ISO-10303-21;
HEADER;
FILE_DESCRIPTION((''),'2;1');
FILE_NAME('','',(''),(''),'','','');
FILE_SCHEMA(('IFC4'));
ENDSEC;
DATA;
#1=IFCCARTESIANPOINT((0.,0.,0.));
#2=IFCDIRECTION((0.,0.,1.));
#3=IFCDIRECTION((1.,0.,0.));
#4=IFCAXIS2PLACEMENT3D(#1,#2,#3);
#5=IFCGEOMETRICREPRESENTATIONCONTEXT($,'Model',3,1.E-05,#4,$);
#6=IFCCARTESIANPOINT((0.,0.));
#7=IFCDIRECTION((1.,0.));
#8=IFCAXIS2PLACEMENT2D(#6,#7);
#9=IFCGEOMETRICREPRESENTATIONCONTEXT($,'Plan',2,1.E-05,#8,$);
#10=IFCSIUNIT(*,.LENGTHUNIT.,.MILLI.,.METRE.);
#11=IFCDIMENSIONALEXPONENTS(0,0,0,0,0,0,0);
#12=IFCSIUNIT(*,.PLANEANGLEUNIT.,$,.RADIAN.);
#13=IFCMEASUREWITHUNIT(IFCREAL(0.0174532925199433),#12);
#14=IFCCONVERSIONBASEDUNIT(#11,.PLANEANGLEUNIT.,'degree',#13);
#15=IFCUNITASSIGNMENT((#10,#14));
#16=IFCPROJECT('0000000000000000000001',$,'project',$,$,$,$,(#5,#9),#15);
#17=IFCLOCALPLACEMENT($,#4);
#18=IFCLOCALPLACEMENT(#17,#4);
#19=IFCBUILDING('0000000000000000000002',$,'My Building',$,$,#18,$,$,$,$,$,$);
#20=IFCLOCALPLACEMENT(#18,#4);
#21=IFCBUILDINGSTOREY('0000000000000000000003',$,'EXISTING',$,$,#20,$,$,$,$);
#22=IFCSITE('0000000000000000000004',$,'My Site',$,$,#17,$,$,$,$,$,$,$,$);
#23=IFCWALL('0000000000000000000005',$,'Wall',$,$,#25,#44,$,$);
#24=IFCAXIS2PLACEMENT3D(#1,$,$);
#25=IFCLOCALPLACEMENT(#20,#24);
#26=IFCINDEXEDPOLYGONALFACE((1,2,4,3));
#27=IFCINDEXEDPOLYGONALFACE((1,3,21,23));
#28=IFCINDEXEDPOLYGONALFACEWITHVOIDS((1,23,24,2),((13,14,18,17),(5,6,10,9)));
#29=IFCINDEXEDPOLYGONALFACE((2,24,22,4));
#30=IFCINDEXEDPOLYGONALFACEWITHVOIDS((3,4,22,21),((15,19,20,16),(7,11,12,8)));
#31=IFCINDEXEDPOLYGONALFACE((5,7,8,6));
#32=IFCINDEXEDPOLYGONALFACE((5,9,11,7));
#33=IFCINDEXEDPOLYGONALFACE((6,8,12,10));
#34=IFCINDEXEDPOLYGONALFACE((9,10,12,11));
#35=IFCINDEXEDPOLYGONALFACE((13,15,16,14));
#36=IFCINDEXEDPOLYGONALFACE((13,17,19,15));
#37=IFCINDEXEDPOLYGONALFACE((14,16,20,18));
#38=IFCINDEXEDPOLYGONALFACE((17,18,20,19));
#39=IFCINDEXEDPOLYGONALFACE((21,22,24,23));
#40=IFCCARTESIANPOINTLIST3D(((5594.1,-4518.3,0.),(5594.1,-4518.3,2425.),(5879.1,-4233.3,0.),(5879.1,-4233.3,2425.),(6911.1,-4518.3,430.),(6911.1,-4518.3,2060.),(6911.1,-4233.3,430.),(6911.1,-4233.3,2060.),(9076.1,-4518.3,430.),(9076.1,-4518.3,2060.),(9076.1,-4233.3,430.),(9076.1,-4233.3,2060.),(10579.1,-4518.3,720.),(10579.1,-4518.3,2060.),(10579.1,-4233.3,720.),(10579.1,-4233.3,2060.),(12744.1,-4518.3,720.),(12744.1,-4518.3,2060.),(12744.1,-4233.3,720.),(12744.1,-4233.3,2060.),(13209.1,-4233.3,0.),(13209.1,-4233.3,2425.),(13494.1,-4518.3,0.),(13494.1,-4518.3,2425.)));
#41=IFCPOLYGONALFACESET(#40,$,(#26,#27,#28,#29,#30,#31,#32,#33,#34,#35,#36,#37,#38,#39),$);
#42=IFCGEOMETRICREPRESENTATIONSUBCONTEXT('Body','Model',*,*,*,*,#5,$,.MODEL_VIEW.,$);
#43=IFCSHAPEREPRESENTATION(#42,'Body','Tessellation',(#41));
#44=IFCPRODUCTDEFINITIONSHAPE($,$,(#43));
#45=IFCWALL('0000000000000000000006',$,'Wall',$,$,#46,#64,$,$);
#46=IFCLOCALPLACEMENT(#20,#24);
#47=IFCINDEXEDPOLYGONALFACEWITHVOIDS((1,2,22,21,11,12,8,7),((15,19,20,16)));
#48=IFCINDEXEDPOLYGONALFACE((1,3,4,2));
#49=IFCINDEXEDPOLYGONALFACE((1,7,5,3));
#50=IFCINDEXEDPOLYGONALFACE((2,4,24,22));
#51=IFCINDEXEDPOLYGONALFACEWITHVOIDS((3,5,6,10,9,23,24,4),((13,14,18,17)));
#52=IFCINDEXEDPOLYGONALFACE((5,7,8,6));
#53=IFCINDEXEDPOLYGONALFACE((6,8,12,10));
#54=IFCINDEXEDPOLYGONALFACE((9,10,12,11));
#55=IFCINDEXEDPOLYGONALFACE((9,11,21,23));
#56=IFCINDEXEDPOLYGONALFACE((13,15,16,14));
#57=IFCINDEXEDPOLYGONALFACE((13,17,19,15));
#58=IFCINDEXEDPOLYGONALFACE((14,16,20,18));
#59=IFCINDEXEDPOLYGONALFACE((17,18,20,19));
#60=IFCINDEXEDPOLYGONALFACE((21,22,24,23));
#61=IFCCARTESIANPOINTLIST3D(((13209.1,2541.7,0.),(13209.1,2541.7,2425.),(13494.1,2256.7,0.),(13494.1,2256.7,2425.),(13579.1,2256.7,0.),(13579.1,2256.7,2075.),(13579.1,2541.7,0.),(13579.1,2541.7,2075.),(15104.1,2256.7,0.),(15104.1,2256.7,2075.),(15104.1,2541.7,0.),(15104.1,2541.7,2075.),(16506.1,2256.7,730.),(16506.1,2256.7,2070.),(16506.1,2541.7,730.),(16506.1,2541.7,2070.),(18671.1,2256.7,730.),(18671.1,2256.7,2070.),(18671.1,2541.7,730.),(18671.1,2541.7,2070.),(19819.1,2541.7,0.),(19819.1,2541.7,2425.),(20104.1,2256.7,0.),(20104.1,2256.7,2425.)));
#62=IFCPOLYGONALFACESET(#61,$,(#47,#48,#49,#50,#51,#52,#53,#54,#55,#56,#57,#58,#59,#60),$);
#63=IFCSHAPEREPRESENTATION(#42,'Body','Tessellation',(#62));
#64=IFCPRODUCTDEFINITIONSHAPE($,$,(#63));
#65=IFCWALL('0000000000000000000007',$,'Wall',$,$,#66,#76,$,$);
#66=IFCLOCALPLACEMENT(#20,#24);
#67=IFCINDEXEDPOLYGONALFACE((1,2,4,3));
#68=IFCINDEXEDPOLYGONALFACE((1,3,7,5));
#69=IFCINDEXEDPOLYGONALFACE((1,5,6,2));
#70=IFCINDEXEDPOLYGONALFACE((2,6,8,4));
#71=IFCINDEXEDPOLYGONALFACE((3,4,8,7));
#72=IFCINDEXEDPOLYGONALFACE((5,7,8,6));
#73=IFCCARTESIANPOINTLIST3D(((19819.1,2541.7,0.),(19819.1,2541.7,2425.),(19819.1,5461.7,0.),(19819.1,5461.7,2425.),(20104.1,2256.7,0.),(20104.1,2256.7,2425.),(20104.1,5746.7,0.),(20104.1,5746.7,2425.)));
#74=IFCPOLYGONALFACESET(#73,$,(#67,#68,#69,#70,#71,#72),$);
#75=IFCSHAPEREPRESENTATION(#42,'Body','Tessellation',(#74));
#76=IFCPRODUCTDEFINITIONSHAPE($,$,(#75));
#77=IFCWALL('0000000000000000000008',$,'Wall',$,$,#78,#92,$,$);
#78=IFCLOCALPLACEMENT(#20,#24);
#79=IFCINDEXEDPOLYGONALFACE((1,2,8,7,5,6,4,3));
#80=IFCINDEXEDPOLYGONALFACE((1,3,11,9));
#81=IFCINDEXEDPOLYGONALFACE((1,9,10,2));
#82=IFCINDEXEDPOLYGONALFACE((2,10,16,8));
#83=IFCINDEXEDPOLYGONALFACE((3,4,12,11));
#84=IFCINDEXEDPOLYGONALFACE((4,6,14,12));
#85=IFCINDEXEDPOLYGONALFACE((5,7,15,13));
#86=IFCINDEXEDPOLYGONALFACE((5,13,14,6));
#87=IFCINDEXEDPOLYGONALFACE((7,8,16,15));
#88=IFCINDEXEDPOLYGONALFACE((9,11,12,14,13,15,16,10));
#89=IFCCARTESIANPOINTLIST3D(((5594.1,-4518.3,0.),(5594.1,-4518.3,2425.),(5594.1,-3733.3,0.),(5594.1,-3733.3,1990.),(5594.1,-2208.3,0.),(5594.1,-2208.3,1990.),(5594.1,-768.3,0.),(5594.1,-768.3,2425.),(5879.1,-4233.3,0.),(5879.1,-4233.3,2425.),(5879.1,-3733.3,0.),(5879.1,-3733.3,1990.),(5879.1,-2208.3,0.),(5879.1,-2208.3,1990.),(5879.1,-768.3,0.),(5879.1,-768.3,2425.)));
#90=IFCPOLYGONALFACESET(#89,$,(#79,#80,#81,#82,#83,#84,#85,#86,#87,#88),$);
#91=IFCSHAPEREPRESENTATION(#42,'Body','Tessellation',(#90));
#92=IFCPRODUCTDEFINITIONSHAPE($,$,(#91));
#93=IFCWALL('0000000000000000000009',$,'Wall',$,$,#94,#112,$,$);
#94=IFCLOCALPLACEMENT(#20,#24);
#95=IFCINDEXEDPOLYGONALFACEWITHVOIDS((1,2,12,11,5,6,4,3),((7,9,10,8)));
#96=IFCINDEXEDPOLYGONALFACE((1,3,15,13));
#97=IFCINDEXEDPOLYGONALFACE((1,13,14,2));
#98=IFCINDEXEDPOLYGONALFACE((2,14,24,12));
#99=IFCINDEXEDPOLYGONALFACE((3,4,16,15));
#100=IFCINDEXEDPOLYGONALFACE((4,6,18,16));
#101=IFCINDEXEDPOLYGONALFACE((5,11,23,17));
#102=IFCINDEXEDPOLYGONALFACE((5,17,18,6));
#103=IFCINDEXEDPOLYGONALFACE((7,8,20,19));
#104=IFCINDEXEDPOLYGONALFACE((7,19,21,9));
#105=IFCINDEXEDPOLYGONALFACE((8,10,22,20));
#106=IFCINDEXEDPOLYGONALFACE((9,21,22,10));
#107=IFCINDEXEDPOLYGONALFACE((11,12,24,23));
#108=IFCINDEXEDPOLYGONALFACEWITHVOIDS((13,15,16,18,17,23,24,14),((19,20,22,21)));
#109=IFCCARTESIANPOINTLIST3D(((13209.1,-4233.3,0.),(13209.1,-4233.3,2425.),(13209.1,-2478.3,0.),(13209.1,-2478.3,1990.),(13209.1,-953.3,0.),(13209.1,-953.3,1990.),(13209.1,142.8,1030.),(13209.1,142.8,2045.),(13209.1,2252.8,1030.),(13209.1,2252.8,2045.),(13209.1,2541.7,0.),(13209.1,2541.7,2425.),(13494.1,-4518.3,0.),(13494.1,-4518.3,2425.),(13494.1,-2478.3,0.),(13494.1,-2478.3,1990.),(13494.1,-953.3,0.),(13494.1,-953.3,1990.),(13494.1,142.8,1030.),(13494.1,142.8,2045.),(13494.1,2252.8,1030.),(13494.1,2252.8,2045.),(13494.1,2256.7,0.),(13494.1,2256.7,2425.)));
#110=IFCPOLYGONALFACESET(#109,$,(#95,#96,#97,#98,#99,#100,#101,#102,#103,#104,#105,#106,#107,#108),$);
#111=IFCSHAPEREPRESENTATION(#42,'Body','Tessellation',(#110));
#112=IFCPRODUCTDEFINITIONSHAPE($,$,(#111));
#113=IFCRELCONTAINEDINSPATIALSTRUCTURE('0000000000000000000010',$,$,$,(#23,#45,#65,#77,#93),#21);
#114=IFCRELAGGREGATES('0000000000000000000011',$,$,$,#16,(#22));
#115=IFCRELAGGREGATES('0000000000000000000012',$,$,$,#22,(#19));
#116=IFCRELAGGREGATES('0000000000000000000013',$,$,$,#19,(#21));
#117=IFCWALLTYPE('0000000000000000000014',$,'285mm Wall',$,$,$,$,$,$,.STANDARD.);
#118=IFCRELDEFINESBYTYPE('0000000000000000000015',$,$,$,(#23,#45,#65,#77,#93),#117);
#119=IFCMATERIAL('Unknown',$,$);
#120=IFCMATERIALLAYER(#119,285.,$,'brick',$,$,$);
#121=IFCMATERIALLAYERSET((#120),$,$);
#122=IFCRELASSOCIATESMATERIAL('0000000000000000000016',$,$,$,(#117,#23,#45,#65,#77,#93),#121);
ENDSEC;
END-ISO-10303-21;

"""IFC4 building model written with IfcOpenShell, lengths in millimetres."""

from ifc_helpers import new_model, entity, si_unit, converted_unit, frame, origin_with_axes, origin_2d_with_axis, place, context, subcontext, project, spatial, line, indexed_curve, outline, extrude, clip, halfspace, source, transform, mapped, material, layer, layer_set, layer_usage, type_object, element, save


model = new_model("IFC4")

# Units and contexts
model_context = context("Model", 3, precision=1e-05, world=origin_with_axes())
plan_context = context("Plan", 2, precision=1e-05, world=origin_2d_with_axis())
body_context = subcontext(model_context, "Body", "Model", "MODEL_VIEW")
ifc_project = project(units=[si_unit("LENGTHUNIT", "METRE", prefix="MILLI"), converted_unit("PLANEANGLEUNIT", "degree", entity("IfcReal", 0.0174532925199433), si_unit("PLANEANGLEUNIT", "RADIAN"), dimensions=[0, 0, 0, 0, 0, 0, 0])], contexts=[model_context, plan_context])

# Site, building, storey
site_placement = place(None, origin_with_axes())
site = spatial("IfcSite", under=ifc_project, at=site_placement, Name="My Site")
building_placement = place(site_placement, origin_with_axes())
building = spatial("IfcBuilding", under=site, at=building_placement, Name="My Building")
storey_placement = place(building_placement, origin_with_axes())
storey = spatial("IfcBuildingStorey", under=building, at=storey_placement, Name="EXISTING")

# Shared definitions
ifc_material = material(Name="Unknown")

# Walls, openings
ifc_layer_1 = layer(ifc_material, 285.0, Name="brick")
ifc_layer_set_1 = layer_set([ifc_layer_1])
ifc_layer_usage_1 = layer_usage(ifc_layer_set_1, "AXIS2", "POSITIVE", 0.0)
wall_type_1 = type_object("IfcWallType", Name="285mm Wall", PredefinedType="STANDARD", material=ifc_layer_set_1)
wall_1_placement = place(storey_placement, frame((5594.1, -4518.3, 0.0), z_axis=(0.0, 0.0, 1.0), x_axis=(1.0, 0.0, 0.0)))
wall_1 = element("IfcWall", 1, at=wall_1_placement, inside=storey, type_object=wall_type_1, material=ifc_layer_usage_1, Name="Wall", context=body_context, shape_type="Clipping", body=[
    clip(clip(extrude(outline(indexed_curve([(0.0, 0.0), (0.0, 285.0), (7900.0, 285.0), (7900.0, 0.0), (0.0, 0.0)], self_intersect=False)), origin_with_axes(), (0.0, 0.0, 1.0), 2425.0), halfspace(frame((7900.0, 0.0, 0.0), z_axis=(0.707107, 0.707106, 0.0), x_axis=(0.707106, -0.707107, 0.0)), False)), halfspace(frame((0.0, 0.0, 0.0), z_axis=(-0.707106, 0.707107, 0.0), x_axis=(0.707107, 0.707106, 0.0)), False)),
])
shared_shape_1 = source(origin_with_axes(), body_context, "Body", "SweptSolid", [
    extrude(outline(indexed_curve([(0.0, 0.0), (2165.0, 0.0), (2165.0, 1630.0), (0.0, 1630.0)], segments=[line(1, 2, 3, 4, 1)])), frame((0.0, -600.0, 0.0), z_axis=(0.0, -1.0, 0.0), x_axis=(1.0, 0.0, 0.0)), (0.0, 0.0, -1.0), 1200.0),
])
opening_1_placement = place(wall_1_placement, frame((3482.0, 136.1, 430.0), z_axis=(0.0, 0.0, 1.0), x_axis=(-1.0, 0.0, 0.0)))
element("IfcOpeningElement", 2, at=opening_1_placement, cuts=wall_1, PredefinedType="OPENING", context=body_context, shape_type="MappedRepresentation", body=[
    mapped(shared_shape_1, transform((0.0, 0.0, 0.0), x_axis=(1.0, 0.0, 0.0), y_axis=(0.0, 1.0, 0.0), z_axis=(0.0, 0.0, 1.0), scale=1.0)),
])
shared_shape_2 = source(origin_with_axes(), body_context, "Body", "SweptSolid", [
    extrude(outline(indexed_curve([(0.0, 0.0), (2165.0, 0.0), (2165.0, 1340.0), (0.0, 1340.0)], segments=[line(1, 2, 3, 4, 1)])), frame((0.0, -600.0, 0.0), z_axis=(0.0, -1.0, 0.0), x_axis=(1.0, 0.0, 0.0)), (0.0, 0.0, -1.0), 1200.0),
])
opening_2_placement = place(wall_1_placement, frame((7150.0, 136.1, 720.0), z_axis=(0.0, 0.0, 1.0), x_axis=(-1.0, 0.0, 0.0)))
element("IfcOpeningElement", 3, at=opening_2_placement, cuts=wall_1, PredefinedType="OPENING", context=body_context, shape_type="MappedRepresentation", body=[
    mapped(shared_shape_2, transform((0.0, 0.0, 0.0), x_axis=(1.0, 0.0, 0.0), y_axis=(0.0, 1.0, 0.0), z_axis=(0.0, 0.0, 1.0), scale=1.0)),
])
ifc_layer_usage_2 = layer_usage(ifc_layer_set_1, "AXIS2", "POSITIVE", 0.0)
wall_2_placement = place(storey_placement, frame((13209.1, 2256.7, 0.0), z_axis=(0.0, 0.0, 1.0), x_axis=(1.0, 0.0, 0.0)))
wall_2 = element("IfcWall", 4, at=wall_2_placement, inside=storey, type_object=wall_type_1, material=ifc_layer_usage_2, Name="Wall", context=body_context, shape_type="Clipping", body=[
    clip(clip(extrude(outline(indexed_curve([(0.0, 0.0), (0.0, 285.0), (6895.0, 285.0), (6895.0, 0.0), (0.0, 0.0)], self_intersect=False)), origin_with_axes(), (0.0, 0.0, 1.0), 2425.0), halfspace(frame((285.0, 0.0, 0.0), z_axis=(-0.707107, -0.707107, 0.0), x_axis=(-0.707107, 0.707107, 0.0)), False)), halfspace(frame((6895.0, 0.0, 0.0), z_axis=(0.707107, 0.707107, 0.0), x_axis=(0.707107, -0.707107, 0.0)), False)),
])
opening_3_placement = place(wall_2_placement, frame((5462.0, 136.1, 730.0), z_axis=(0.0, 0.0, 1.0), x_axis=(-1.0, 0.0, 0.0)))
element("IfcOpeningElement", 5, at=opening_3_placement, cuts=wall_2, PredefinedType="OPENING", context=body_context, shape_type="MappedRepresentation", body=[
    mapped(shared_shape_2, transform((0.0, 0.0, 0.0), x_axis=(1.0, 0.0, 0.0), y_axis=(0.0, 1.0, 0.0), z_axis=(0.0, 0.0, 1.0), scale=1.0)),
])
shared_shape_3 = source(origin_with_axes(), body_context, "Body", "SweptSolid", [
    extrude(outline(indexed_curve([(0.0, 0.0), (1525.0, 0.0), (1525.0, 2075.0), (0.0, 2075.0)], segments=[line(1, 2, 3, 4, 1)])), frame((0.0, -600.0, 0.0), z_axis=(0.0, -1.0, 0.0), x_axis=(1.0, 0.0, 0.0)), (0.0, 0.0, -1.0), 1200.0),
])
opening_4_placement = place(wall_2_placement, frame((1895.0, -33.8, 0.0), z_axis=(0.0, 0.0, 1.0), x_axis=(-1.0, 0.0, 0.0)))
element("IfcOpeningElement", 6, at=opening_4_placement, cuts=wall_2, PredefinedType="OPENING", context=body_context, shape_type="MappedRepresentation", body=[
    mapped(shared_shape_3, transform((0.0, 0.0, 0.0), x_axis=(1.0, 0.0, 0.0), y_axis=(0.0, 1.0, 0.0), z_axis=(0.0, 0.0, 1.0), scale=1.0)),
])

# Wall
ifc_layer_usage_3 = layer_usage(ifc_layer_set_1, "AXIS2", "POSITIVE", 0.0)
wall_3_placement = place(storey_placement, frame((20104.1, 2256.7, 0.0), z_axis=(0.0, 0.0, 1.0), x_axis=(0.0, 1.0, 0.0)))
element("IfcWall", 7, at=wall_3_placement, inside=storey, type_object=wall_type_1, material=ifc_layer_usage_3, Name="Wall", context=body_context, shape_type="Clipping", body=[
    clip(clip(extrude(outline(indexed_curve([(0.0, 0.0), (0.0, 285.0), (3490.0, 285.0), (3490.0, 0.0), (0.0, 0.0)], self_intersect=False)), origin_with_axes(), (0.0, 0.0, 1.0), 2425.0), halfspace(frame((0.0, 0.0, 0.0), z_axis=(-0.707107, 0.707107, 0.0), x_axis=(0.707107, 0.707107, 0.0)), False)), halfspace(frame((3490.0, 0.0, 0.0), z_axis=(0.707107, 0.707107, 0.0), x_axis=(0.707107, -0.707107, 0.0)), False)),
])

# Wall, opening
ifc_layer_usage_4 = layer_usage(ifc_layer_set_1, "AXIS2", "POSITIVE", 0.0)
wall_4_placement = place(storey_placement, frame((5879.1, -4518.3, 0.0), z_axis=(0.0, 0.0, 1.0), x_axis=(0.0, 1.0, 0.0)))
wall_4 = element("IfcWall", 8, at=wall_4_placement, inside=storey, type_object=wall_type_1, material=ifc_layer_usage_4, Name="Wall", context=body_context, shape_type="Clipping", body=[
    clip(extrude(outline(indexed_curve([(0.0, 0.0), (0.0, 285.0), (3750.0, 285.0), (3750.0, 0.0), (0.0, 0.0)], self_intersect=False)), origin_with_axes(), (0.0, 0.0, 1.0), 2425.0), halfspace(frame((285.0, 0.0, 0.0), z_axis=(-0.707107, -0.707107, 0.0), x_axis=(-0.707107, 0.707107, 0.0)), False)),
])
shared_shape_4 = source(origin_with_axes(), body_context, "Body", "SweptSolid", [
    extrude(outline(indexed_curve([(0.0, 0.0), (1525.0, 0.0), (1525.0, 1990.0), (0.0, 1990.0)], segments=[line(1, 2, 3, 4, 1)])), frame((0.0, -600.0, 0.0), z_axis=(0.0, -1.0, 0.0), x_axis=(1.0, 0.0, 0.0)), (0.0, 0.0, -1.0), 1200.0),
])
opening_5_placement = place(wall_4_placement, frame((785.0, 0.0, 0.0), z_axis=(0.0, 0.0, 1.0), x_axis=(1.0, 0.0, 0.0)))
element("IfcOpeningElement", 9, at=opening_5_placement, cuts=wall_4, PredefinedType="OPENING", context=body_context, shape_type="MappedRepresentation", body=[
    mapped(shared_shape_4, transform((0.0, 0.0, 0.0), x_axis=(1.0, 0.0, 0.0), y_axis=(0.0, 1.0, 0.0), z_axis=(0.0, 0.0, 1.0), scale=1.0)),
])

# Wall, openings
ifc_layer_usage_5 = layer_usage(ifc_layer_set_1, "AXIS2", "POSITIVE", 0.0)
wall_5_placement = place(storey_placement, frame((13494.1, -4518.3, 0.0), z_axis=(0.0, 0.0, 1.0), x_axis=(0.0, 1.0, 0.0)))
wall_5 = element("IfcWall", 10, at=wall_5_placement, inside=storey, type_object=wall_type_1, material=ifc_layer_usage_5, Name="Wall", context=body_context, shape_type="Clipping", body=[
    clip(clip(extrude(outline(indexed_curve([(0.0, 0.0), (0.0, 285.0), (7060.0, 285.0), (7060.0, 0.0), (0.0, 0.0)], self_intersect=False)), origin_with_axes(), (0.0, 0.0, 1.0), 2425.0), halfspace(frame((0.0, 0.0, 0.0), z_axis=(-0.707107, 0.707107, 0.0), x_axis=(0.707107, 0.707107, 0.0)), False)), halfspace(frame((6775.0, 0.0, 0.0), z_axis=(0.707107, -0.707107, 0.0), x_axis=(-0.707107, -0.707107, 0.0)), False)),
])
shared_shape_5 = source(origin_with_axes(), body_context, "Body", "SweptSolid", [
    extrude(outline(indexed_curve([(0.0, 0.0), (2110.0, 0.0), (2110.0, 1015.0), (0.0, 1015.0)], segments=[line(1, 2, 3, 4, 1)])), frame((0.0, -600.0, 0.0), z_axis=(0.0, -1.0, 0.0), x_axis=(1.0, 0.0, 0.0)), (0.0, 0.0, -1.0), 1200.0),
])
opening_6_placement = place(wall_5_placement, frame((6771.2, 136.1, 1030.0), z_axis=(0.0, 0.0, 1.0), x_axis=(-1.0, 0.0, 0.0)))
element("IfcOpeningElement", 11, at=opening_6_placement, cuts=wall_5, PredefinedType="OPENING", context=body_context, shape_type="MappedRepresentation", body=[
    mapped(shared_shape_5, transform((0.0, 0.0, 0.0), x_axis=(1.0, 0.0, 0.0), y_axis=(0.0, 1.0, 0.0), z_axis=(0.0, 0.0, 1.0), scale=1.0)),
])
shared_shape_6 = source(origin_with_axes(), body_context, "Body", "SweptSolid", [
    extrude(outline(indexed_curve([(0.0, 0.0), (1525.0, 0.0), (1525.0, 1990.0), (0.0, 1990.0)], segments=[line(1, 2, 3, 4, 1)])), frame((0.0, -600.0, 0.0), z_axis=(0.0, -1.0, 0.0), x_axis=(1.0, 0.0, 0.0)), (0.0, 0.0, -1.0), 1200.0),
])
opening_7_placement = place(wall_5_placement, frame((3565.0, 146.1, 0.0), z_axis=(0.0, 0.0, 1.0), x_axis=(-1.0, 0.0, 0.0)))
element("IfcOpeningElement", 12, at=opening_7_placement, cuts=wall_5, PredefinedType="OPENING", context=body_context, shape_type="MappedRepresentation", body=[
    mapped(shared_shape_6, transform((0.0, 0.0, 0.0), x_axis=(1.0, 0.0, 0.0), y_axis=(0.0, 1.0, 0.0), z_axis=(0.0, 0.0, 1.0), scale=1.0)),
])

save(model, "model.ifc")
